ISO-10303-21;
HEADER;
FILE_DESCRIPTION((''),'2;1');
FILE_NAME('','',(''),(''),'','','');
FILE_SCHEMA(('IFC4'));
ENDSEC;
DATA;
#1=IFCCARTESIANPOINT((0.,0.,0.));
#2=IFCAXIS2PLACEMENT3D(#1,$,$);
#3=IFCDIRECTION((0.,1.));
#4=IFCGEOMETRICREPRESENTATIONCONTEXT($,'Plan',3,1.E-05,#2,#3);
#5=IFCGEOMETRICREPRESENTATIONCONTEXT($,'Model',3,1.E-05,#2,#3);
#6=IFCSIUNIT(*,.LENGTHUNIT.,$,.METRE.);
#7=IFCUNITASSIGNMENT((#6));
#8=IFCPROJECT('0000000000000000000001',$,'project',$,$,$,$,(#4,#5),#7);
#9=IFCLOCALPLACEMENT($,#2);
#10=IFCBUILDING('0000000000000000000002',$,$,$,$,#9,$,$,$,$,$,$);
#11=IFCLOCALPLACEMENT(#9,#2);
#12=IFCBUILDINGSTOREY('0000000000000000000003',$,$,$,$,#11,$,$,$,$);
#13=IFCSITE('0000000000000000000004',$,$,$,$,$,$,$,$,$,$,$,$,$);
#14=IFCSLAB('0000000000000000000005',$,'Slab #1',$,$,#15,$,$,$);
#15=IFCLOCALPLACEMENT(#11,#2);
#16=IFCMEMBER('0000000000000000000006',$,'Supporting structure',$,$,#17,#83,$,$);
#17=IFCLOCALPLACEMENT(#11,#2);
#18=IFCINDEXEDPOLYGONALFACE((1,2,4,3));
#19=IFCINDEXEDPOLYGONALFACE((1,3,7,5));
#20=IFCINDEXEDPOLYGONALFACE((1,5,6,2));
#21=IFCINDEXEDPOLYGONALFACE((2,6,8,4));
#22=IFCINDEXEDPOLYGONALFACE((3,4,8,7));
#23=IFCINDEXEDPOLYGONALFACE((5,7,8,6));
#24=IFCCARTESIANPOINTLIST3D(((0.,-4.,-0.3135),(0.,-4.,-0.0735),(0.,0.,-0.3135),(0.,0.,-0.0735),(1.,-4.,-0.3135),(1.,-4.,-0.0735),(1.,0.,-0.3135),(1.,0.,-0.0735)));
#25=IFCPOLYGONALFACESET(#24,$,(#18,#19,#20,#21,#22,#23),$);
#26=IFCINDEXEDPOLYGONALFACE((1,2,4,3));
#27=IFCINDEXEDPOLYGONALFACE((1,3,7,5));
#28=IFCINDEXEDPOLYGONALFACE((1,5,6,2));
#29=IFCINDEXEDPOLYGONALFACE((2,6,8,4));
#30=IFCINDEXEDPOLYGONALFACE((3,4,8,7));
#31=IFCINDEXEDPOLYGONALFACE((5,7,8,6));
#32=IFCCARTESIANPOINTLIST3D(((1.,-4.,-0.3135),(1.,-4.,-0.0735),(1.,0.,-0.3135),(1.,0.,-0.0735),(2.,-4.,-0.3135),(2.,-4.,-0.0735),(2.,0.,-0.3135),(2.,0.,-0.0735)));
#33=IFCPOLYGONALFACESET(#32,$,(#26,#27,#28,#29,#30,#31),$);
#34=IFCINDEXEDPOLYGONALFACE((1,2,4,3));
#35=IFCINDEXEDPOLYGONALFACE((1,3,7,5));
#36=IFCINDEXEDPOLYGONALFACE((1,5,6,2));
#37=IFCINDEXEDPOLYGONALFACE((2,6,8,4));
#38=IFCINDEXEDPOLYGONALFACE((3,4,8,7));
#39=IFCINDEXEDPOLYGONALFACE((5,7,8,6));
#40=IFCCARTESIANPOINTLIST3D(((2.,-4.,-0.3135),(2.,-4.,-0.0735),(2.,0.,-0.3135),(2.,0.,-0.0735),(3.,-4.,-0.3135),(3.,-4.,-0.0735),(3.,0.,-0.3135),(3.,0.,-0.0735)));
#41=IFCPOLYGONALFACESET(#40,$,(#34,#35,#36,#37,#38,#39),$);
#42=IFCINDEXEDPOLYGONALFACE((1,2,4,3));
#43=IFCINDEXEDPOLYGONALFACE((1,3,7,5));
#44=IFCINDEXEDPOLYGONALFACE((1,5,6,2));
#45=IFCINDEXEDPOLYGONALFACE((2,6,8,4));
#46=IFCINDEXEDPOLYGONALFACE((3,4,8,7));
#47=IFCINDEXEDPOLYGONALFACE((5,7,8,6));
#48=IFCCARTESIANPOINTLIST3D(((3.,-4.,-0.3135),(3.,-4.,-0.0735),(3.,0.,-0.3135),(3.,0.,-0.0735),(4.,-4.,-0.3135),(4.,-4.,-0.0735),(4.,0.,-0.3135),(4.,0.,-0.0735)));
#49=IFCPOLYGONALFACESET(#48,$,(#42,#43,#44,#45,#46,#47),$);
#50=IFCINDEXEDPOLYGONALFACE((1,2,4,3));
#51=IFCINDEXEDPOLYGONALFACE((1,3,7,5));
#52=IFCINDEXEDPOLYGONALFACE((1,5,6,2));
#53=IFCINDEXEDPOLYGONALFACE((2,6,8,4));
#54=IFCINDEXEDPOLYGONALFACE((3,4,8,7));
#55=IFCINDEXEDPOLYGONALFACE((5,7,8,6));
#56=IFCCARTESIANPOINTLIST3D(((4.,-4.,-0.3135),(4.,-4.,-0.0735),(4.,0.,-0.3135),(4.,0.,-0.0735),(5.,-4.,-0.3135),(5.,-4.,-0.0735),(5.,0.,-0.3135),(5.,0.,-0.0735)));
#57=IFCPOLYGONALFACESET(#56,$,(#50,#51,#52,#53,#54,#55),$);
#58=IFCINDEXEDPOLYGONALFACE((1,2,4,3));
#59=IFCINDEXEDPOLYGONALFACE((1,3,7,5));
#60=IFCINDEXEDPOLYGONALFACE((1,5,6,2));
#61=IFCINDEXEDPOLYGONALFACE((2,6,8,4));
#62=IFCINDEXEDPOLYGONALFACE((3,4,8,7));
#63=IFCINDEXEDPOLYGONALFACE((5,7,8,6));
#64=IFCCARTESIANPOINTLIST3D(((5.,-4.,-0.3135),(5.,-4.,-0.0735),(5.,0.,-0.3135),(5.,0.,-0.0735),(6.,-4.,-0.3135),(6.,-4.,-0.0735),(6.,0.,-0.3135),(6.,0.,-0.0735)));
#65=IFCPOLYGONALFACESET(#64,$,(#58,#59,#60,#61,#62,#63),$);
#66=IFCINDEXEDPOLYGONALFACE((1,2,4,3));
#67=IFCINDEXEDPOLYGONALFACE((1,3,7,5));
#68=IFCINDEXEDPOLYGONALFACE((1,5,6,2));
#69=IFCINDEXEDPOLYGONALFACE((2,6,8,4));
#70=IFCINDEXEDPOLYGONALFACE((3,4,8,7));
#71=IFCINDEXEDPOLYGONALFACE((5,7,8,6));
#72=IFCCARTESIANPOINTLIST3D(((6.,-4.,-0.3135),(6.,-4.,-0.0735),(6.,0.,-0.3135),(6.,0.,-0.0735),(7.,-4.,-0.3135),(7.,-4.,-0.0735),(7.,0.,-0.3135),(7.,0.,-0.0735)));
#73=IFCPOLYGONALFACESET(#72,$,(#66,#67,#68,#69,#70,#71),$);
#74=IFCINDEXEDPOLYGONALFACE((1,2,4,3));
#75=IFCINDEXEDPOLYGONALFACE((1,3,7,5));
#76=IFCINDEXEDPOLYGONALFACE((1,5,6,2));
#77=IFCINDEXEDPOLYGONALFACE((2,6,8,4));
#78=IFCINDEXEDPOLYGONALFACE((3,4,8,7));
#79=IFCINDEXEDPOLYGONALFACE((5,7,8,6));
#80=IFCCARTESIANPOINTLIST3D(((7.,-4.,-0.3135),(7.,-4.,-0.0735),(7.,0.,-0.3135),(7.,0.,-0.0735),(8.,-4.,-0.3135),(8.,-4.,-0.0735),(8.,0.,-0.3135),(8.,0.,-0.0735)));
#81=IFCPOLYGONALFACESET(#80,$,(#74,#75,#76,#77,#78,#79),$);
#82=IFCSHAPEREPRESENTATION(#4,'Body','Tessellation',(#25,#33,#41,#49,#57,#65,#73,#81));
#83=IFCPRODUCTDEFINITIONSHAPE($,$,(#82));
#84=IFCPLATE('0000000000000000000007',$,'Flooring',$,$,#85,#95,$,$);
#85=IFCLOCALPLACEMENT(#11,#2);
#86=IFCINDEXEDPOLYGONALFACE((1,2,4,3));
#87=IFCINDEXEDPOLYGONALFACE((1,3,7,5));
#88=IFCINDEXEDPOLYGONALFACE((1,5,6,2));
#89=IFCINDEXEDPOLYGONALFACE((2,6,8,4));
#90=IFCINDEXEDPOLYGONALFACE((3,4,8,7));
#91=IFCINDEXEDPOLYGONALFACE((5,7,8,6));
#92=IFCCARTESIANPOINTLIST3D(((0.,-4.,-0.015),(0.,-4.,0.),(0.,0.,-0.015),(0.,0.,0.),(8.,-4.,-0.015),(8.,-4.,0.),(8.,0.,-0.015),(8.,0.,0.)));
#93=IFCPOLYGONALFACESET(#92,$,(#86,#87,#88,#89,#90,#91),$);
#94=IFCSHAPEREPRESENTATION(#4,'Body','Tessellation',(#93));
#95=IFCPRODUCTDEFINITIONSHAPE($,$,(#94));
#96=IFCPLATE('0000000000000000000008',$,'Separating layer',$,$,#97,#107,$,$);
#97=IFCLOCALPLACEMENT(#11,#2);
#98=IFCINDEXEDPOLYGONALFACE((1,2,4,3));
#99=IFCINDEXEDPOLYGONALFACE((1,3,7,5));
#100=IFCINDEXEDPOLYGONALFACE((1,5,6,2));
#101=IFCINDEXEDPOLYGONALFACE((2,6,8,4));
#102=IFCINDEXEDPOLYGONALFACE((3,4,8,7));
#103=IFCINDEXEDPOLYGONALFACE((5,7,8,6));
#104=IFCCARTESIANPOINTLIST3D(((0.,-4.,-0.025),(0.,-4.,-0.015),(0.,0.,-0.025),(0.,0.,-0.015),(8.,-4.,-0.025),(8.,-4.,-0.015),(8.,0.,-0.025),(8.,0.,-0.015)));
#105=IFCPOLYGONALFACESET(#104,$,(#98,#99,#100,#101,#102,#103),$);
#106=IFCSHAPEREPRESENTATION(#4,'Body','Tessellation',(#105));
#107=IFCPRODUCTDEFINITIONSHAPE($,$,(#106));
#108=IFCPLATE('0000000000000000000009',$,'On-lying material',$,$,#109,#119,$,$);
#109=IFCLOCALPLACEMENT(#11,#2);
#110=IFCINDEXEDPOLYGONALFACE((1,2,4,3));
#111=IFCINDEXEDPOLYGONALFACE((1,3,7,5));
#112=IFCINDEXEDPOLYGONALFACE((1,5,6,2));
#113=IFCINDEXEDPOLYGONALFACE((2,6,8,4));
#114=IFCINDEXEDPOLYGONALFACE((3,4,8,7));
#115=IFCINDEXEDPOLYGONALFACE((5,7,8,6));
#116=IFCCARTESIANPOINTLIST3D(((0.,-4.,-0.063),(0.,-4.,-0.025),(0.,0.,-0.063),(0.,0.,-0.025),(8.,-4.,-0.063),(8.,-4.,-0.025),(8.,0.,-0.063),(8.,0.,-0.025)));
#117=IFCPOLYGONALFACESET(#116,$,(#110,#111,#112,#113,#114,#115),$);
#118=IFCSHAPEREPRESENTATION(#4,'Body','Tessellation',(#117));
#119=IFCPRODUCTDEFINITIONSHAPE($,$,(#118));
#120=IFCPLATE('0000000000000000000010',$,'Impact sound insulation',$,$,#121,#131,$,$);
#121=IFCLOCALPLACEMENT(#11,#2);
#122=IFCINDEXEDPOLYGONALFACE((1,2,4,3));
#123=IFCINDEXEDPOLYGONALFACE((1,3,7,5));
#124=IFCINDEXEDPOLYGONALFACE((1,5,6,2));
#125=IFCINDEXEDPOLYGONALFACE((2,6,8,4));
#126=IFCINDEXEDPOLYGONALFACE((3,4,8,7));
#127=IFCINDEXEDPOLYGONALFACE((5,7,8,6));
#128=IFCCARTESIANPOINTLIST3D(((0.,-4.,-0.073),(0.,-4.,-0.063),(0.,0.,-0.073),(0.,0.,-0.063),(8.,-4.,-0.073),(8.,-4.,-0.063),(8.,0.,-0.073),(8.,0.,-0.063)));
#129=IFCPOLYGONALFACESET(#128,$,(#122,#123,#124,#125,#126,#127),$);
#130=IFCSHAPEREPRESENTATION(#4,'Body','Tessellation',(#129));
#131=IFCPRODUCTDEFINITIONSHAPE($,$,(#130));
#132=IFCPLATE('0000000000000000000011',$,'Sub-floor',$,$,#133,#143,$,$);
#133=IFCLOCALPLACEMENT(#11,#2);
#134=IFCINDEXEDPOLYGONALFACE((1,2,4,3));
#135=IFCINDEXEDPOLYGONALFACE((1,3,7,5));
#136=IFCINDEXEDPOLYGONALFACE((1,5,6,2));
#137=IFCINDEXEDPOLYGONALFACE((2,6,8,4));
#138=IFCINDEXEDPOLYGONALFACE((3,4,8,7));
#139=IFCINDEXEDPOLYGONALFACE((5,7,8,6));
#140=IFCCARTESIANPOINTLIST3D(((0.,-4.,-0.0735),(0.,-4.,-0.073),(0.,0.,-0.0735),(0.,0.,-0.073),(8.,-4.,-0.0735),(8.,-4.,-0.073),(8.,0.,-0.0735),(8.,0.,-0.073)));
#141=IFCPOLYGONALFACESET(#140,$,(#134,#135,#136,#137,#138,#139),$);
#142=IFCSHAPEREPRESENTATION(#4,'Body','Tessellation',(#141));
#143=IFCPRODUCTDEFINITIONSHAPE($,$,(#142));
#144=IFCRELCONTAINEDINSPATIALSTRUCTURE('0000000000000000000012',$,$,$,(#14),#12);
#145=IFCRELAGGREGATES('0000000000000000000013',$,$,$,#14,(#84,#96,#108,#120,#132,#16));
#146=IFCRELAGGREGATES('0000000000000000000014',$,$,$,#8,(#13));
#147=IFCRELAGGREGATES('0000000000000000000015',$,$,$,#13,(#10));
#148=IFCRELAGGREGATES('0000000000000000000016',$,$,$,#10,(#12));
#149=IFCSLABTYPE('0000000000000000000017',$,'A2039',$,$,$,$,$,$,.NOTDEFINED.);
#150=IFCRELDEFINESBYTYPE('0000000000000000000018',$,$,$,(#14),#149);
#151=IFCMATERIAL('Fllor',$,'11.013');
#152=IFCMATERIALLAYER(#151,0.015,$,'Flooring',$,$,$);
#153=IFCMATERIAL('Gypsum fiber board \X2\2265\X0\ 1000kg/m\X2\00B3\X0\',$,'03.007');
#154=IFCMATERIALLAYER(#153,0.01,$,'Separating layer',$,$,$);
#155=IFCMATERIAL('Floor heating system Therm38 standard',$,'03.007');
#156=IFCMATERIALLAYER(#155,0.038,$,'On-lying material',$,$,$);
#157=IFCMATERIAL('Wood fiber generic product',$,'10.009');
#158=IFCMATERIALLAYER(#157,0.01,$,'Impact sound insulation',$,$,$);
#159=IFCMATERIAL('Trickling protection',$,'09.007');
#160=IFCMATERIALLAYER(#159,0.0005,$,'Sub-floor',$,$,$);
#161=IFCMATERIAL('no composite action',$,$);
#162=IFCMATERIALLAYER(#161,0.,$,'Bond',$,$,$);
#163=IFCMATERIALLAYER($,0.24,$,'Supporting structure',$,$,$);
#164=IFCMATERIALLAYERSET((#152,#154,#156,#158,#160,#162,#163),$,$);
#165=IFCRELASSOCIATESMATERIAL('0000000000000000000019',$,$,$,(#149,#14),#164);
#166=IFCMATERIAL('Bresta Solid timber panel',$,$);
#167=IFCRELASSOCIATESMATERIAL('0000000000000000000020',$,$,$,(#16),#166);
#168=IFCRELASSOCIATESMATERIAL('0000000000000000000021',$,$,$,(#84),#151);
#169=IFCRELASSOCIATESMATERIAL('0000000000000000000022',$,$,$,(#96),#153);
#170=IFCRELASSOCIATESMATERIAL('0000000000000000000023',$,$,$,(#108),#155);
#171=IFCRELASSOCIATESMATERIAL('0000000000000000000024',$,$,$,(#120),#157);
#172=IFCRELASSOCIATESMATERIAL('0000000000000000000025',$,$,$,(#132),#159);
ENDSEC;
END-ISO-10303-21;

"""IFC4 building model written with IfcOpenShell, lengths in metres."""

from ifc_helpers import new_model, si_unit, direction, frame, frame_2d, origin, origin_with_axes, place, context, project, spatial, rectangle, extrude, material, layer, layer_set, type_object, element, aggregate, save


model = new_model("IFC4")

# Units and contexts
plan_context = context("Plan", 3, precision=1e-05, world=origin(), true_north=direction((0.0, 1.0)))
model_context = context("Model", 3, precision=1e-05, world=origin(), true_north=direction((0.0, 1.0)))
ifc_project = project(units=[si_unit("LENGTHUNIT", "METRE")], contexts=[plan_context, model_context])

# Site, building, storey
site = spatial("IfcSite", under=ifc_project)
building_placement = place(None, origin())
building = spatial("IfcBuilding", under=site, at=building_placement)
storey_placement = place(building_placement, origin())
storey = spatial("IfcBuildingStorey", under=building, at=storey_placement)

# Slab, member, plates
ifc_material_1 = material(Name="Fllor", Category="11.013")
ifc_layer_1 = layer(ifc_material_1, 0.015, Name="Flooring")
ifc_material_2 = material(Name="Gypsum fiber board ≥ 1000kg/m³", Category="03.007")
ifc_layer_2 = layer(ifc_material_2, 0.01, Name="Separating layer")
ifc_material_3 = material(Name="Floor heating system Therm38 standard", Category="03.007")
ifc_layer_3 = layer(ifc_material_3, 0.038, Name="On-lying material")
ifc_material_4 = material(Name="Wood fiber generic product", Category="10.009")
ifc_layer_4 = layer(ifc_material_4, 0.01, Name="Impact sound insulation")
ifc_material_5 = material(Name="Trickling protection", Category="09.007")
ifc_layer_5 = layer(ifc_material_5, 0.0005, Name="Sub-floor")
ifc_material_6 = material(Name="no composite action")
ifc_layer_6 = layer(ifc_material_6, 0.0, Name="Bond")
ifc_layer_7 = layer(None, 0.24, Name="Supporting structure")
ifc_layer_set = layer_set([ifc_layer_1, ifc_layer_2, ifc_layer_3, ifc_layer_4, ifc_layer_5, ifc_layer_6, ifc_layer_7])
slab_type = type_object("IfcSlabType", Name="A2039", PredefinedType="NOTDEFINED", material=ifc_layer_set)
slab_placement = place(None, frame((0.0, 0.0, 0.0), z_axis=(0.0, 0.0, -1.0), x_axis=(1.0, 0.0, 0.0)))
slab = element("IfcSlab", 1, at=slab_placement, inside=storey, type_object=slab_type, material=ifc_layer_set, Name="Slab #1")
ifc_material_7 = material(Name="Bresta Solid timber panel")
member_placement = place(slab_placement, origin())
member = element("IfcMember", 2, at=member_placement, material=ifc_material_7, Name="Supporting structure", context=plan_context, shape_type="SweptSolid", body=[
    extrude(rectangle(XDim=1.0, YDim=0.24, at=frame_2d((0.5, 0.12), x_axis=(1.0, 0.0))), frame((0.0, 4.0, 0.0735), z_axis=(0.0, -1.0, 0.0), x_axis=(1.0, 0.0, 0.0)), (0.0, 0.0, 1.0), 4.0),
    extrude(rectangle(XDim=1.0, YDim=0.24, at=frame_2d((0.5, 0.12), x_axis=(1.0, 0.0))), frame((1.0, 4.0, 0.0735), z_axis=(0.0, -1.0, 0.0), x_axis=(1.0, 0.0, 0.0)), (0.0, 0.0, 1.0), 4.0),
    extrude(rectangle(XDim=1.0, YDim=0.24, at=frame_2d((0.5, 0.12), x_axis=(1.0, 0.0))), frame((2.0, 4.0, 0.0735), z_axis=(0.0, -1.0, 0.0), x_axis=(1.0, 0.0, 0.0)), (0.0, 0.0, 1.0), 4.0),
    extrude(rectangle(XDim=1.0, YDim=0.24, at=frame_2d((0.5, 0.12), x_axis=(1.0, 0.0))), frame((3.0, 4.0, 0.0735), z_axis=(0.0, -1.0, 0.0), x_axis=(1.0, 0.0, 0.0)), (0.0, 0.0, 1.0), 4.0),
    extrude(rectangle(XDim=1.0, YDim=0.24, at=frame_2d((0.5, 0.12), x_axis=(1.0, 0.0))), frame((4.0, 4.0, 0.0735), z_axis=(0.0, -1.0, 0.0), x_axis=(1.0, 0.0, 0.0)), (0.0, 0.0, 1.0), 4.0),
    extrude(rectangle(XDim=1.0, YDim=0.24, at=frame_2d((0.5, 0.12), x_axis=(1.0, 0.0))), frame((5.0, 4.0, 0.0735), z_axis=(0.0, -1.0, 0.0), x_axis=(1.0, 0.0, 0.0)), (0.0, 0.0, 1.0), 4.0),
    extrude(rectangle(XDim=1.0, YDim=0.24, at=frame_2d((0.5, 0.12), x_axis=(1.0, 0.0))), frame((6.0, 4.0, 0.0735), z_axis=(0.0, -1.0, 0.0), x_axis=(1.0, 0.0, 0.0)), (0.0, 0.0, 1.0), 4.0),
    extrude(rectangle(XDim=1.0, YDim=0.24, at=frame_2d((0.5, 0.12), x_axis=(1.0, 0.0))), frame((7.0, 4.0, 0.0735), z_axis=(0.0, -1.0, 0.0), x_axis=(1.0, 0.0, 0.0)), (0.0, 0.0, 1.0), 4.0),
])
plate_1_placement = place(slab_placement, origin())
plate_1 = element("IfcPlate", 3, at=plate_1_placement, material=ifc_material_1, Name="Flooring", context=plan_context, shape_type="SweptSolid", body=[
    extrude(rectangle(XDim=8.0, YDim=4.0, at=frame_2d((4.0, 2.0), x_axis=(1.0, 0.0))), origin_with_axes(), (0.0, 0.0, 1.0), 0.015),
])
plate_2_placement = place(slab_placement, origin())
plate_2 = element("IfcPlate", 4, at=plate_2_placement, material=ifc_material_2, Name="Separating layer", context=plan_context, shape_type="SweptSolid", body=[
    extrude(rectangle(XDim=8.0, YDim=4.0, at=frame_2d((4.0, 2.0), x_axis=(1.0, 0.0))), frame((0.0, 0.0, 0.015), z_axis=(0.0, 0.0, 1.0), x_axis=(1.0, 0.0, 0.0)), (0.0, 0.0, 1.0), 0.01),
])
plate_3_placement = place(slab_placement, origin())
plate_3 = element("IfcPlate", 5, at=plate_3_placement, material=ifc_material_3, Name="On-lying material", context=plan_context, shape_type="SweptSolid", body=[
    extrude(rectangle(XDim=8.0, YDim=4.0, at=frame_2d((4.0, 2.0), x_axis=(1.0, 0.0))), frame((0.0, 0.0, 0.025), z_axis=(0.0, 0.0, 1.0), x_axis=(1.0, 0.0, 0.0)), (0.0, 0.0, 1.0), 0.038),
])
plate_4_placement = place(slab_placement, origin())
plate_4 = element("IfcPlate", 6, at=plate_4_placement, material=ifc_material_4, Name="Impact sound insulation", context=plan_context, shape_type="SweptSolid", body=[
    extrude(rectangle(XDim=8.0, YDim=4.0, at=frame_2d((4.0, 2.0), x_axis=(1.0, 0.0))), frame((0.0, 0.0, 0.063), z_axis=(0.0, 0.0, 1.0), x_axis=(1.0, 0.0, 0.0)), (0.0, 0.0, 1.0), 0.01),
])
plate_5_placement = place(slab_placement, origin())
plate_5 = element("IfcPlate", 7, at=plate_5_placement, material=ifc_material_5, Name="Sub-floor", context=plan_context, shape_type="SweptSolid", body=[
    extrude(rectangle(XDim=8.0, YDim=4.0, at=frame_2d((4.0, 2.0), x_axis=(1.0, 0.0))), frame((0.0, 0.0, 0.073), z_axis=(0.0, 0.0, 1.0), x_axis=(1.0, 0.0, 0.0)), (0.0, 0.0, 1.0), 0.0005),
])
aggregate(slab, [plate_1, plate_2, plate_3, plate_4, plate_5, member])

save(model, "model.ifc")
